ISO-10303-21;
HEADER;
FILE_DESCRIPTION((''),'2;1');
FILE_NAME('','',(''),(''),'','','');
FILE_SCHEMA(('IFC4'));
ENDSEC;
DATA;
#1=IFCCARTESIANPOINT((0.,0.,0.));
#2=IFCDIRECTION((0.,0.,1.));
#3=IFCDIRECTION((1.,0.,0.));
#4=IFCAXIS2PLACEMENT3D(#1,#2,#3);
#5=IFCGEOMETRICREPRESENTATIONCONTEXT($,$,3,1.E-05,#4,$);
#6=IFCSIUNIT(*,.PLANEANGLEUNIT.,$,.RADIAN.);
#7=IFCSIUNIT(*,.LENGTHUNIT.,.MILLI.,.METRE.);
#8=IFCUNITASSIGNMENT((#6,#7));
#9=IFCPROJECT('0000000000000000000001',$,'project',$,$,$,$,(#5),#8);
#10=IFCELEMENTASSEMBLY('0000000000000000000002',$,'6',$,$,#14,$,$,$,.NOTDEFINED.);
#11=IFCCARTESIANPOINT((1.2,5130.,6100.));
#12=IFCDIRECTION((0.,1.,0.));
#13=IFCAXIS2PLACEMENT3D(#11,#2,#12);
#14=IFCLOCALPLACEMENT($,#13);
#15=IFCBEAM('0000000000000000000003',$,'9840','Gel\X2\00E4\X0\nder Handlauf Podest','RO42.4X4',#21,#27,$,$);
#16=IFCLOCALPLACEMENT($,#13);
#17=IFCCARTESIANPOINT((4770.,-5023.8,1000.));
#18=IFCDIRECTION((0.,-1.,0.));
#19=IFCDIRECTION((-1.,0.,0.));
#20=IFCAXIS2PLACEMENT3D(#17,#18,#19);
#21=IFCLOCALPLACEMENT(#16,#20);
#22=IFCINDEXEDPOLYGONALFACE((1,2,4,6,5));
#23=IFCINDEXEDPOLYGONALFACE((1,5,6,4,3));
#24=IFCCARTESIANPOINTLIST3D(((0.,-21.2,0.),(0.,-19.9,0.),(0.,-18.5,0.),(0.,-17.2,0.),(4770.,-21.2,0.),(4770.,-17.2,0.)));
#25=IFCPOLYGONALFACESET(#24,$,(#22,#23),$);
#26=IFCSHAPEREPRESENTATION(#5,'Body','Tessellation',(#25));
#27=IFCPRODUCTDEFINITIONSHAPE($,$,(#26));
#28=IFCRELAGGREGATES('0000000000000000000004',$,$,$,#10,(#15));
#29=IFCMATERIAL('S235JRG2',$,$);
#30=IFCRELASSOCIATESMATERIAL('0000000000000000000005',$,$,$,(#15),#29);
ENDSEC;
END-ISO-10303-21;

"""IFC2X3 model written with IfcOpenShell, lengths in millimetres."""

from ifc_helpers import new_model, si_unit, frame, origin_with_axes, place, context, project, polyline, outline, extrude, material, element, aggregate, save


model = new_model("IFC2X3")

# Units and contexts
context_of_model = context(None, 3, precision=1e-05, world=origin_with_axes())
ifc_project = project(units=[si_unit("PLANEANGLEUNIT", "RADIAN"), si_unit("LENGTHUNIT", "METRE", prefix="MILLI")], contexts=[context_of_model])

# Element assembly, beam
assembly_placement = place(None, frame((1.2, 5130.0, 6100.0), z_axis=(0.0, 0.0, 1.0), x_axis=(0.0, 1.0, 0.0)))
assembly = element("IfcElementAssembly", 1, at=assembly_placement, Name="6", PredefinedType="NOTDEFINED")
ifc_material = material(Name="S235JRG2")
placement_1 = place(None, frame((1.2, 5130.0, 6100.0), z_axis=(0.0, 0.0, 1.0), x_axis=(0.0, 1.0, 0.0)))
beam_1_placement = place(placement_1, frame((4770.0, -5023.8, 1000.0), z_axis=(0.0, -1.0, 0.0), x_axis=(-1.0, 0.0, 0.0)))
beam_1 = element("IfcBeam", 2, at=beam_1_placement, material=ifc_material, Name="9840", Description="Geländer Handlauf Podest", ObjectType="RO42.4X4", context=context_of_model, shape_type="SweptSolid", body=[
    extrude(outline(polyline([(-21.2, 0.0), (-21.2, 0.0), (-17.2, 0.0), (-17.2, 0.0), (-21.2, 0.0)])), frame((0.0, 0.0, 0.0), z_axis=(1.0, 0.0, 0.0), x_axis=(0.0, 1.0, 0.0)), (0.0, 0.0, 1.0), 4770.0),
])
aggregate(assembly, [beam_1])

save(model, "model.ifc")
